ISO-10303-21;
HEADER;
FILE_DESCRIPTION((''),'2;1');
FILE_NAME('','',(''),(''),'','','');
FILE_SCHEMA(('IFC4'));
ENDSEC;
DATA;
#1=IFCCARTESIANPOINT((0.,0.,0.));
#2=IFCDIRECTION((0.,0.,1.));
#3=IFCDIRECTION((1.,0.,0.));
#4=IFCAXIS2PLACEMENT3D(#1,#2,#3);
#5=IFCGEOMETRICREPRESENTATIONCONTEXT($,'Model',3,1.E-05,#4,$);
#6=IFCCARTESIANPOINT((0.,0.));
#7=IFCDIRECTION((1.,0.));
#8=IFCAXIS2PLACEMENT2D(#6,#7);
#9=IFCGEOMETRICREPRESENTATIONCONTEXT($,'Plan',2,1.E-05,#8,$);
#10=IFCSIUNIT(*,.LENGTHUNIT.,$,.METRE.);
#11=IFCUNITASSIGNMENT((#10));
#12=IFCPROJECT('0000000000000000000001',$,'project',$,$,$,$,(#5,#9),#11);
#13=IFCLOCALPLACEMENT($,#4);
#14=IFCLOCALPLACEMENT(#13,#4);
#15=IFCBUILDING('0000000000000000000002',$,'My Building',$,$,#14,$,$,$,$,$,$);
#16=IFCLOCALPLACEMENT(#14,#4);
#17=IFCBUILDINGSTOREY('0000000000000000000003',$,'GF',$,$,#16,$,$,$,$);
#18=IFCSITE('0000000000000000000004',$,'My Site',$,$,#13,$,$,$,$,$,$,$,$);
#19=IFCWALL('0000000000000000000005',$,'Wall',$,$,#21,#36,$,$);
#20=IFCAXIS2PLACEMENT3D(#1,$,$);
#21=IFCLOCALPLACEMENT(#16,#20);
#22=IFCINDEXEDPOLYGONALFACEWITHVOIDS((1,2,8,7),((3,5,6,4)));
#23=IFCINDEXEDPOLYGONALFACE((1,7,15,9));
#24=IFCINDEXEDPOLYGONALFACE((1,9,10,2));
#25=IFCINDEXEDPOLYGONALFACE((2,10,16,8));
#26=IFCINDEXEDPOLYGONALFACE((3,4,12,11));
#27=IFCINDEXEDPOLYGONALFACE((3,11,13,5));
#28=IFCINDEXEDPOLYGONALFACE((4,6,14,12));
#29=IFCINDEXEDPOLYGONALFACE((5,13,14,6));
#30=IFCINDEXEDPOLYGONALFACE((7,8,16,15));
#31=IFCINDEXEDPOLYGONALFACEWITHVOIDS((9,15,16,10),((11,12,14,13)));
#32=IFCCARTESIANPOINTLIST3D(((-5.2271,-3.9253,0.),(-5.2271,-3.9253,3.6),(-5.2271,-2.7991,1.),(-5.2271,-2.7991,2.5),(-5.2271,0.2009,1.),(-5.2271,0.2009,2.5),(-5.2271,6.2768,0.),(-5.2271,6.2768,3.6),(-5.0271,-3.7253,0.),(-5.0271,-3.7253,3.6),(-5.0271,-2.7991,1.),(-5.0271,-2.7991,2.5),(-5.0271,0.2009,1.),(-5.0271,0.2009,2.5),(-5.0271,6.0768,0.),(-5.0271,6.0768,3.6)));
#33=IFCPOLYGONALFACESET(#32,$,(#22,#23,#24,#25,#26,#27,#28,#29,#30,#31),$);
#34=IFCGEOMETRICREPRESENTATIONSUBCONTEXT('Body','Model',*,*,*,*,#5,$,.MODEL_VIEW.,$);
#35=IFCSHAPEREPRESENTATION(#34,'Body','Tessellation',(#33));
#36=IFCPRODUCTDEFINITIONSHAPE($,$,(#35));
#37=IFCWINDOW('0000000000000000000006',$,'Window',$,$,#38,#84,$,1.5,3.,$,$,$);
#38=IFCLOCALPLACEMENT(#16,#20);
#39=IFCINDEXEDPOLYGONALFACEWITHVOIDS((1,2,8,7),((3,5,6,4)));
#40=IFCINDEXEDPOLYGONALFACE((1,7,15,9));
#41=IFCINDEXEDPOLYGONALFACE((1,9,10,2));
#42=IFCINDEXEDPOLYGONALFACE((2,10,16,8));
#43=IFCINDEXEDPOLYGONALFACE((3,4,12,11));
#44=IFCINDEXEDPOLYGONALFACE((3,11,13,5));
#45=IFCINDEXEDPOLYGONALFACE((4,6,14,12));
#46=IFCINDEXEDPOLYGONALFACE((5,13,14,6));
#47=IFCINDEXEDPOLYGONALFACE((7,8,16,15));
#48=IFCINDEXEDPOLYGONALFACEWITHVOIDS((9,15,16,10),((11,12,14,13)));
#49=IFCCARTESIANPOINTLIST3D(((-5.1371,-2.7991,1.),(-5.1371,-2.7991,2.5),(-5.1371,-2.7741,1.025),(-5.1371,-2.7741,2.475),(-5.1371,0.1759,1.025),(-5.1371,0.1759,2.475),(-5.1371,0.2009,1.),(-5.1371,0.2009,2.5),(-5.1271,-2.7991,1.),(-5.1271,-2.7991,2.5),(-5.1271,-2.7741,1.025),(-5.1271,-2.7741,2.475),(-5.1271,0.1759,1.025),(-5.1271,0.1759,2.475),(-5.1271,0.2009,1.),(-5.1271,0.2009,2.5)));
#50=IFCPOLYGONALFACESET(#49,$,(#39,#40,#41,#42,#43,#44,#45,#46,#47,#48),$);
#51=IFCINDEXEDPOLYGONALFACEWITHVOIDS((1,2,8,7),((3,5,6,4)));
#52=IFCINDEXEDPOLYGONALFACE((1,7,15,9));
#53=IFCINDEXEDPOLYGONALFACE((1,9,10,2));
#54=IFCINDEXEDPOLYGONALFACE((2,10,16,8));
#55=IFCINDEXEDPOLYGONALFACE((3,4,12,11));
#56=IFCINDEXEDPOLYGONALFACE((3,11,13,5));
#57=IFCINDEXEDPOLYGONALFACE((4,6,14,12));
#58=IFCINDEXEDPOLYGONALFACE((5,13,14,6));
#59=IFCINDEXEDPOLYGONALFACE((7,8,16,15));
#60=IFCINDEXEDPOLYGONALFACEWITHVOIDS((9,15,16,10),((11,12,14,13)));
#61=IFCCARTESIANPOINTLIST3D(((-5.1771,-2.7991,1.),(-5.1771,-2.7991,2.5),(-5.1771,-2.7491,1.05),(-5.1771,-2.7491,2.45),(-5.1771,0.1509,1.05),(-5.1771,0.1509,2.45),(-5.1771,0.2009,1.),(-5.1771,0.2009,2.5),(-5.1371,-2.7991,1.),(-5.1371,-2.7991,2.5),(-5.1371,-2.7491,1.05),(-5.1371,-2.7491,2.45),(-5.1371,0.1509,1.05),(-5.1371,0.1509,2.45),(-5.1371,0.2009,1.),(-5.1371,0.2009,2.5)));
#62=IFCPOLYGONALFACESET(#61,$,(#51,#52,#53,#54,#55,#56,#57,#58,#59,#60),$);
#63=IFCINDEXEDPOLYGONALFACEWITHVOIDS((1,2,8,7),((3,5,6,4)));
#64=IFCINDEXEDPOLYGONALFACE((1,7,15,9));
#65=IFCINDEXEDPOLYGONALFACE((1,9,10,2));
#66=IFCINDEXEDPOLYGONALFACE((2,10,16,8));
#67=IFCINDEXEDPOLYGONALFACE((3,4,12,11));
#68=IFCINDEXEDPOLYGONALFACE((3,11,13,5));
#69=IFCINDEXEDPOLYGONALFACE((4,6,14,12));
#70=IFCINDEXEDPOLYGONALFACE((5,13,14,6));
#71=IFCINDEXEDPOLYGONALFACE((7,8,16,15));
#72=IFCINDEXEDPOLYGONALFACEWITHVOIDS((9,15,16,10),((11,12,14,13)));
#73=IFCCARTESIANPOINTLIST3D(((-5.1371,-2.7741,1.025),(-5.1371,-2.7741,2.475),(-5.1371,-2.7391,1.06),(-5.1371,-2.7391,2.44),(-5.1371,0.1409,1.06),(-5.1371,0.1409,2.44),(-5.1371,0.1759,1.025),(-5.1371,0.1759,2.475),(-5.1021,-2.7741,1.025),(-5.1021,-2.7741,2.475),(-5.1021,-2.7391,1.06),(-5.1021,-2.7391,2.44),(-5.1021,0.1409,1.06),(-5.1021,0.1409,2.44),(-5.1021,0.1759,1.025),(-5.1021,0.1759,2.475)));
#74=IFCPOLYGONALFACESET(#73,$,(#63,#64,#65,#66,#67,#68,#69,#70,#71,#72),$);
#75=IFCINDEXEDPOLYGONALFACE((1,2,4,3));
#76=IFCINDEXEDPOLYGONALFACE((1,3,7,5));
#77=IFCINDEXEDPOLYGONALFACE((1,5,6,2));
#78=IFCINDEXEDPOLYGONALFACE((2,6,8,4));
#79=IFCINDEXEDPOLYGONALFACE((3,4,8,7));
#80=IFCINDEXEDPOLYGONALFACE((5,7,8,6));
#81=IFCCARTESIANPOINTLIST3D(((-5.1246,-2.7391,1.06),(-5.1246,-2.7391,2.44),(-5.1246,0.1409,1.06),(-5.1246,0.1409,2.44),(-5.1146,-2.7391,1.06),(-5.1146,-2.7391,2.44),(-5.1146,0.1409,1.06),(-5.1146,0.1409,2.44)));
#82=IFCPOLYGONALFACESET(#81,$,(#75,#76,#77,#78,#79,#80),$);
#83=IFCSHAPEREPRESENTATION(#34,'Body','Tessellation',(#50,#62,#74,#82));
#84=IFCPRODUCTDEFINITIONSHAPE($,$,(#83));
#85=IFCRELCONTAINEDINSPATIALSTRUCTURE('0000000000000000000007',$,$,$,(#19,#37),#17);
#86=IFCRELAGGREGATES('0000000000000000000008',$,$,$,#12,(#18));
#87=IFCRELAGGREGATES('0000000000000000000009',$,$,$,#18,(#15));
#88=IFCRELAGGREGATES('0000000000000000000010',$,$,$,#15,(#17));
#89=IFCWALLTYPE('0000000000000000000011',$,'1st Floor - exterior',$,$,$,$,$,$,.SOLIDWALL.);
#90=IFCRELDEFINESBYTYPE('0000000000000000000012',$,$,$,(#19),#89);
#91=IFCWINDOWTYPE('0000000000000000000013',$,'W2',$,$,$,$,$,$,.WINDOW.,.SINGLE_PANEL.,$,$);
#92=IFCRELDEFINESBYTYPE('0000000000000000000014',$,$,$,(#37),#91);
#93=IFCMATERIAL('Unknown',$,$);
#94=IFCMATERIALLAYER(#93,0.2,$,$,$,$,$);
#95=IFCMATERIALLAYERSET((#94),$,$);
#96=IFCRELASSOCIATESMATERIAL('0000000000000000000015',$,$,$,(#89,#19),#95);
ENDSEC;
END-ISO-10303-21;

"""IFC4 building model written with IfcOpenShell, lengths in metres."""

from ifc_helpers import new_model, entity, si_unit, frame, origin_with_axes, origin_2d_with_axis, place, context, subcontext, project, spatial, line, indexed_curve, outline, extrude, shape, source, transform, mapped, material, layer, layer_set, layer_usage, type_object, type_shapes, element, fill, save


model = new_model("IFC4")

# Units and contexts
model_context = context("Model", 3, precision=1e-05, world=origin_with_axes())
plan_context = context("Plan", 2, precision=1e-05, world=origin_2d_with_axis())
body_context_1 = subcontext(model_context, "Body", "Model", "MODEL_VIEW")
body_context_2 = subcontext(plan_context, "Body", "Plan", "PLAN_VIEW")
ifc_project = project(units=[si_unit("LENGTHUNIT", "METRE")], contexts=[model_context, plan_context])

# Site, building, storey
site_placement = place(None, origin_with_axes())
site = spatial("IfcSite", under=ifc_project, at=site_placement, Name="My Site")
building_placement = place(site_placement, origin_with_axes())
building = spatial("IfcBuilding", under=site, at=building_placement, Name="My Building")
storey_placement = place(building_placement, origin_with_axes())
storey = spatial("IfcBuildingStorey", under=building, at=storey_placement, Name="GF")

# Shared definitions
ifc_material = material(Name="Unknown")

# Shared definitions
ifc_layer_1 = layer(ifc_material, 0.2)
ifc_layer_set_1 = layer_set([ifc_layer_1])
wall_type_1 = type_object("IfcWallType", Name="1st Floor - exterior", PredefinedType="SOLIDWALL", material=ifc_layer_set_1)

# Wall, opening, window
ifc_layer_usage_1 = layer_usage(ifc_layer_set_1, "AXIS2", "POSITIVE", 0.0)
wall_1_placement = place(storey_placement, frame((-5.0271, -3.7253, 0.0), z_axis=(0.0, 0.0, 1.0), x_axis=(0.0, 1.0, 0.0)))
wall_1 = element("IfcWall", 1, at=wall_1_placement, inside=storey, type_object=wall_type_1, material=ifc_layer_usage_1, Name="Wall", context=body_context_1, shape_type="SweptSolid", body=[
    extrude(outline(indexed_curve([(0.0, 0.0), (-0.2, 0.2), (10.0021, 0.2), (9.8021, 0.0)], segments=[line(1, 2, 3, 4, 1)])), origin_with_axes(), (0.0, 0.0, 1.0), 3.6),
])
shared_shape_1 = source(origin_with_axes(), body_context_1, "Body", "SweptSolid", [
    extrude(outline(indexed_curve([(0.0, 0.0), (3.0, 0.0), (3.0, 1.5), (0.0, 1.5)], segments=[line(1, 2, 3, 4, 1)])), frame((0.0, -0.6, 0.0), z_axis=(0.0, -1.0, 0.0), x_axis=(1.0, 0.0, 0.0)), (0.0, 0.0, -1.0), 1.2),
])
opening_1_placement = place(wall_1_placement, frame((3.9262, 0.2, 1.0), z_axis=(0.0, 0.0, 1.0), x_axis=(-1.0, 0.0, 0.0)))
opening_1 = element("IfcOpeningElement", 2, at=opening_1_placement, cuts=wall_1, PredefinedType="OPENING", context=body_context_1, shape_type="MappedRepresentation", body=[
    mapped(shared_shape_1, transform((0.0, 0.0, 0.0), x_axis=(1.0, 0.0, 0.0), y_axis=(0.0, 1.0, 0.0), z_axis=(0.0, 0.0, 1.0), scale=1.0)),
])
window_type_1 = type_object("IfcWindowType", Name="W2", PartitioningType="SINGLE_PANEL", PredefinedType="WINDOW")
shared_shape_2 = source(origin_with_axes(), body_context_1, "Body", "SweptSolid", [
    extrude(outline(indexed_curve([(0.0, 0.0), (3.0, 0.0), (3.0, 1.5), (0.0, 1.5)], segments=[line(1, 2, 3, 4, 1)]), holes=[indexed_curve([(0.025, 0.025), (2.975, 0.025), (2.975, 1.475), (0.025, 1.475)], segments=[line(1, 2, 3, 4, 1)])]), frame((0.0, 0.09, 0.0), z_axis=(0.0, -1.0, 0.0), x_axis=(1.0, 0.0, 0.0)), (0.0, 0.0, -1.0), 0.01),
    extrude(outline(indexed_curve([(0.0, 0.0), (3.0, 0.0), (3.0, 1.5), (0.0, 1.5)], segments=[line(1, 2, 3, 4, 1)]), holes=[indexed_curve([(0.05, 0.05), (2.95, 0.05), (2.95, 1.45), (0.05, 1.45)], segments=[line(1, 2, 3, 4, 1)])]), frame((0.0, 0.05, 0.0), z_axis=(0.0, -1.0, 0.0), x_axis=(1.0, 0.0, 0.0)), (0.0, 0.0, -1.0), 0.04),
    extrude(outline(indexed_curve([(0.0, 0.0), (2.95, 0.0), (2.95, 1.45), (0.0, 1.45)], segments=[line(1, 2, 3, 4, 1)]), holes=[indexed_curve([(0.035, 0.035), (2.915, 0.035), (2.915, 1.415), (0.035, 1.415)], segments=[line(1, 2, 3, 4, 1)])]), frame((0.025, 0.09, 0.025), z_axis=(0.0, -1.0, 0.0), x_axis=(1.0, 0.0, 0.0)), (0.0, 0.0, -1.0), 0.035),
    extrude(outline(indexed_curve([(0.035, 0.035), (2.915, 0.035), (2.915, 1.415), (0.035, 1.415)], segments=[line(1, 2, 3, 4, 1)])), frame((0.025, 0.1025, 0.025), z_axis=(0.0, -1.0, 0.0), x_axis=(1.0, 0.0, 0.0)), (0.0, 0.0, -1.0), 0.01),
])
shared_shape_3 = source(origin_with_axes(), body_context_2, "Body", "Curve2D", [
    entity("IfcIndexedPolyCurve", entity("IfcCartesianPointList2D", [[0.05, 0.05], [2.95, 0.05]])),
    entity("IfcIndexedPolyCurve", entity("IfcCartesianPointList2D", [[0.0, 0.1], [0.025, 0.1], [0.025, 0.09], [0.05, 0.09], [0.05, 0.05], [0.0, 0.05]]), [entity("IfcLineIndex", [1, 2, 3, 4, 5, 6, 1])]),
    entity("IfcIndexedPolyCurve", entity("IfcCartesianPointList2D", [[3.0, 0.1], [2.975, 0.1], [2.975, 0.09], [2.95, 0.09], [2.95, 0.05], [3.0, 0.05]]), [entity("IfcLineIndex", [1, 2, 3, 4, 5, 6, 1])]),
    entity("IfcIndexedPolyCurve", entity("IfcCartesianPointList2D", [[0.025, 0.09], [0.06, 0.09], [0.06, 0.125], [0.025, 0.125]]), [entity("IfcLineIndex", [1, 2, 3, 4, 1])]),
    entity("IfcIndexedPolyCurve", entity("IfcCartesianPointList2D", [[2.975, 0.09], [2.94, 0.09], [2.94, 0.125], [2.975, 0.125]]), [entity("IfcLineIndex", [1, 2, 3, 4, 1])]),
    entity("IfcIndexedPolyCurve", entity("IfcCartesianPointList2D", [[0.06, 0.09], [2.94, 0.09]])),
    entity("IfcIndexedPolyCurve", entity("IfcCartesianPointList2D", [[0.06, 0.125], [2.94, 0.125]])),
    entity("IfcIndexedPolyCurve", entity("IfcCartesianPointList2D", [[0.06, 0.1075], [2.94, 0.1075]])),
])
type_shapes(window_type_1, [shared_shape_2, shared_shape_3])
window_1_placement = place(opening_1_placement, origin_with_axes())
window_1 = element("IfcWindow", 3, at=window_1_placement, inside=storey, type_object=window_type_1, Name="Window", OverallHeight=1.5, OverallWidth=3.0, shapes=[
    shape(body_context_1, "Body", "MappedRepresentation", [mapped(shared_shape_2, transform((0.0, 0.0, 0.0), x_axis=(1.0, 0.0, 0.0), y_axis=(0.0, 1.0, 0.0), z_axis=(0.0, 0.0, 1.0), scale=1.0))]),
    shape(body_context_2, "Body", "MappedRepresentation", [mapped(shared_shape_3, transform((0.0, 0.0, 0.0), x_axis=(1.0, 0.0, 0.0), y_axis=(0.0, 1.0, 0.0), z_axis=(0.0, 0.0, 1.0), scale=1.0))]),
])
fill(opening_1, window_1)

save(model, "model.ifc")
